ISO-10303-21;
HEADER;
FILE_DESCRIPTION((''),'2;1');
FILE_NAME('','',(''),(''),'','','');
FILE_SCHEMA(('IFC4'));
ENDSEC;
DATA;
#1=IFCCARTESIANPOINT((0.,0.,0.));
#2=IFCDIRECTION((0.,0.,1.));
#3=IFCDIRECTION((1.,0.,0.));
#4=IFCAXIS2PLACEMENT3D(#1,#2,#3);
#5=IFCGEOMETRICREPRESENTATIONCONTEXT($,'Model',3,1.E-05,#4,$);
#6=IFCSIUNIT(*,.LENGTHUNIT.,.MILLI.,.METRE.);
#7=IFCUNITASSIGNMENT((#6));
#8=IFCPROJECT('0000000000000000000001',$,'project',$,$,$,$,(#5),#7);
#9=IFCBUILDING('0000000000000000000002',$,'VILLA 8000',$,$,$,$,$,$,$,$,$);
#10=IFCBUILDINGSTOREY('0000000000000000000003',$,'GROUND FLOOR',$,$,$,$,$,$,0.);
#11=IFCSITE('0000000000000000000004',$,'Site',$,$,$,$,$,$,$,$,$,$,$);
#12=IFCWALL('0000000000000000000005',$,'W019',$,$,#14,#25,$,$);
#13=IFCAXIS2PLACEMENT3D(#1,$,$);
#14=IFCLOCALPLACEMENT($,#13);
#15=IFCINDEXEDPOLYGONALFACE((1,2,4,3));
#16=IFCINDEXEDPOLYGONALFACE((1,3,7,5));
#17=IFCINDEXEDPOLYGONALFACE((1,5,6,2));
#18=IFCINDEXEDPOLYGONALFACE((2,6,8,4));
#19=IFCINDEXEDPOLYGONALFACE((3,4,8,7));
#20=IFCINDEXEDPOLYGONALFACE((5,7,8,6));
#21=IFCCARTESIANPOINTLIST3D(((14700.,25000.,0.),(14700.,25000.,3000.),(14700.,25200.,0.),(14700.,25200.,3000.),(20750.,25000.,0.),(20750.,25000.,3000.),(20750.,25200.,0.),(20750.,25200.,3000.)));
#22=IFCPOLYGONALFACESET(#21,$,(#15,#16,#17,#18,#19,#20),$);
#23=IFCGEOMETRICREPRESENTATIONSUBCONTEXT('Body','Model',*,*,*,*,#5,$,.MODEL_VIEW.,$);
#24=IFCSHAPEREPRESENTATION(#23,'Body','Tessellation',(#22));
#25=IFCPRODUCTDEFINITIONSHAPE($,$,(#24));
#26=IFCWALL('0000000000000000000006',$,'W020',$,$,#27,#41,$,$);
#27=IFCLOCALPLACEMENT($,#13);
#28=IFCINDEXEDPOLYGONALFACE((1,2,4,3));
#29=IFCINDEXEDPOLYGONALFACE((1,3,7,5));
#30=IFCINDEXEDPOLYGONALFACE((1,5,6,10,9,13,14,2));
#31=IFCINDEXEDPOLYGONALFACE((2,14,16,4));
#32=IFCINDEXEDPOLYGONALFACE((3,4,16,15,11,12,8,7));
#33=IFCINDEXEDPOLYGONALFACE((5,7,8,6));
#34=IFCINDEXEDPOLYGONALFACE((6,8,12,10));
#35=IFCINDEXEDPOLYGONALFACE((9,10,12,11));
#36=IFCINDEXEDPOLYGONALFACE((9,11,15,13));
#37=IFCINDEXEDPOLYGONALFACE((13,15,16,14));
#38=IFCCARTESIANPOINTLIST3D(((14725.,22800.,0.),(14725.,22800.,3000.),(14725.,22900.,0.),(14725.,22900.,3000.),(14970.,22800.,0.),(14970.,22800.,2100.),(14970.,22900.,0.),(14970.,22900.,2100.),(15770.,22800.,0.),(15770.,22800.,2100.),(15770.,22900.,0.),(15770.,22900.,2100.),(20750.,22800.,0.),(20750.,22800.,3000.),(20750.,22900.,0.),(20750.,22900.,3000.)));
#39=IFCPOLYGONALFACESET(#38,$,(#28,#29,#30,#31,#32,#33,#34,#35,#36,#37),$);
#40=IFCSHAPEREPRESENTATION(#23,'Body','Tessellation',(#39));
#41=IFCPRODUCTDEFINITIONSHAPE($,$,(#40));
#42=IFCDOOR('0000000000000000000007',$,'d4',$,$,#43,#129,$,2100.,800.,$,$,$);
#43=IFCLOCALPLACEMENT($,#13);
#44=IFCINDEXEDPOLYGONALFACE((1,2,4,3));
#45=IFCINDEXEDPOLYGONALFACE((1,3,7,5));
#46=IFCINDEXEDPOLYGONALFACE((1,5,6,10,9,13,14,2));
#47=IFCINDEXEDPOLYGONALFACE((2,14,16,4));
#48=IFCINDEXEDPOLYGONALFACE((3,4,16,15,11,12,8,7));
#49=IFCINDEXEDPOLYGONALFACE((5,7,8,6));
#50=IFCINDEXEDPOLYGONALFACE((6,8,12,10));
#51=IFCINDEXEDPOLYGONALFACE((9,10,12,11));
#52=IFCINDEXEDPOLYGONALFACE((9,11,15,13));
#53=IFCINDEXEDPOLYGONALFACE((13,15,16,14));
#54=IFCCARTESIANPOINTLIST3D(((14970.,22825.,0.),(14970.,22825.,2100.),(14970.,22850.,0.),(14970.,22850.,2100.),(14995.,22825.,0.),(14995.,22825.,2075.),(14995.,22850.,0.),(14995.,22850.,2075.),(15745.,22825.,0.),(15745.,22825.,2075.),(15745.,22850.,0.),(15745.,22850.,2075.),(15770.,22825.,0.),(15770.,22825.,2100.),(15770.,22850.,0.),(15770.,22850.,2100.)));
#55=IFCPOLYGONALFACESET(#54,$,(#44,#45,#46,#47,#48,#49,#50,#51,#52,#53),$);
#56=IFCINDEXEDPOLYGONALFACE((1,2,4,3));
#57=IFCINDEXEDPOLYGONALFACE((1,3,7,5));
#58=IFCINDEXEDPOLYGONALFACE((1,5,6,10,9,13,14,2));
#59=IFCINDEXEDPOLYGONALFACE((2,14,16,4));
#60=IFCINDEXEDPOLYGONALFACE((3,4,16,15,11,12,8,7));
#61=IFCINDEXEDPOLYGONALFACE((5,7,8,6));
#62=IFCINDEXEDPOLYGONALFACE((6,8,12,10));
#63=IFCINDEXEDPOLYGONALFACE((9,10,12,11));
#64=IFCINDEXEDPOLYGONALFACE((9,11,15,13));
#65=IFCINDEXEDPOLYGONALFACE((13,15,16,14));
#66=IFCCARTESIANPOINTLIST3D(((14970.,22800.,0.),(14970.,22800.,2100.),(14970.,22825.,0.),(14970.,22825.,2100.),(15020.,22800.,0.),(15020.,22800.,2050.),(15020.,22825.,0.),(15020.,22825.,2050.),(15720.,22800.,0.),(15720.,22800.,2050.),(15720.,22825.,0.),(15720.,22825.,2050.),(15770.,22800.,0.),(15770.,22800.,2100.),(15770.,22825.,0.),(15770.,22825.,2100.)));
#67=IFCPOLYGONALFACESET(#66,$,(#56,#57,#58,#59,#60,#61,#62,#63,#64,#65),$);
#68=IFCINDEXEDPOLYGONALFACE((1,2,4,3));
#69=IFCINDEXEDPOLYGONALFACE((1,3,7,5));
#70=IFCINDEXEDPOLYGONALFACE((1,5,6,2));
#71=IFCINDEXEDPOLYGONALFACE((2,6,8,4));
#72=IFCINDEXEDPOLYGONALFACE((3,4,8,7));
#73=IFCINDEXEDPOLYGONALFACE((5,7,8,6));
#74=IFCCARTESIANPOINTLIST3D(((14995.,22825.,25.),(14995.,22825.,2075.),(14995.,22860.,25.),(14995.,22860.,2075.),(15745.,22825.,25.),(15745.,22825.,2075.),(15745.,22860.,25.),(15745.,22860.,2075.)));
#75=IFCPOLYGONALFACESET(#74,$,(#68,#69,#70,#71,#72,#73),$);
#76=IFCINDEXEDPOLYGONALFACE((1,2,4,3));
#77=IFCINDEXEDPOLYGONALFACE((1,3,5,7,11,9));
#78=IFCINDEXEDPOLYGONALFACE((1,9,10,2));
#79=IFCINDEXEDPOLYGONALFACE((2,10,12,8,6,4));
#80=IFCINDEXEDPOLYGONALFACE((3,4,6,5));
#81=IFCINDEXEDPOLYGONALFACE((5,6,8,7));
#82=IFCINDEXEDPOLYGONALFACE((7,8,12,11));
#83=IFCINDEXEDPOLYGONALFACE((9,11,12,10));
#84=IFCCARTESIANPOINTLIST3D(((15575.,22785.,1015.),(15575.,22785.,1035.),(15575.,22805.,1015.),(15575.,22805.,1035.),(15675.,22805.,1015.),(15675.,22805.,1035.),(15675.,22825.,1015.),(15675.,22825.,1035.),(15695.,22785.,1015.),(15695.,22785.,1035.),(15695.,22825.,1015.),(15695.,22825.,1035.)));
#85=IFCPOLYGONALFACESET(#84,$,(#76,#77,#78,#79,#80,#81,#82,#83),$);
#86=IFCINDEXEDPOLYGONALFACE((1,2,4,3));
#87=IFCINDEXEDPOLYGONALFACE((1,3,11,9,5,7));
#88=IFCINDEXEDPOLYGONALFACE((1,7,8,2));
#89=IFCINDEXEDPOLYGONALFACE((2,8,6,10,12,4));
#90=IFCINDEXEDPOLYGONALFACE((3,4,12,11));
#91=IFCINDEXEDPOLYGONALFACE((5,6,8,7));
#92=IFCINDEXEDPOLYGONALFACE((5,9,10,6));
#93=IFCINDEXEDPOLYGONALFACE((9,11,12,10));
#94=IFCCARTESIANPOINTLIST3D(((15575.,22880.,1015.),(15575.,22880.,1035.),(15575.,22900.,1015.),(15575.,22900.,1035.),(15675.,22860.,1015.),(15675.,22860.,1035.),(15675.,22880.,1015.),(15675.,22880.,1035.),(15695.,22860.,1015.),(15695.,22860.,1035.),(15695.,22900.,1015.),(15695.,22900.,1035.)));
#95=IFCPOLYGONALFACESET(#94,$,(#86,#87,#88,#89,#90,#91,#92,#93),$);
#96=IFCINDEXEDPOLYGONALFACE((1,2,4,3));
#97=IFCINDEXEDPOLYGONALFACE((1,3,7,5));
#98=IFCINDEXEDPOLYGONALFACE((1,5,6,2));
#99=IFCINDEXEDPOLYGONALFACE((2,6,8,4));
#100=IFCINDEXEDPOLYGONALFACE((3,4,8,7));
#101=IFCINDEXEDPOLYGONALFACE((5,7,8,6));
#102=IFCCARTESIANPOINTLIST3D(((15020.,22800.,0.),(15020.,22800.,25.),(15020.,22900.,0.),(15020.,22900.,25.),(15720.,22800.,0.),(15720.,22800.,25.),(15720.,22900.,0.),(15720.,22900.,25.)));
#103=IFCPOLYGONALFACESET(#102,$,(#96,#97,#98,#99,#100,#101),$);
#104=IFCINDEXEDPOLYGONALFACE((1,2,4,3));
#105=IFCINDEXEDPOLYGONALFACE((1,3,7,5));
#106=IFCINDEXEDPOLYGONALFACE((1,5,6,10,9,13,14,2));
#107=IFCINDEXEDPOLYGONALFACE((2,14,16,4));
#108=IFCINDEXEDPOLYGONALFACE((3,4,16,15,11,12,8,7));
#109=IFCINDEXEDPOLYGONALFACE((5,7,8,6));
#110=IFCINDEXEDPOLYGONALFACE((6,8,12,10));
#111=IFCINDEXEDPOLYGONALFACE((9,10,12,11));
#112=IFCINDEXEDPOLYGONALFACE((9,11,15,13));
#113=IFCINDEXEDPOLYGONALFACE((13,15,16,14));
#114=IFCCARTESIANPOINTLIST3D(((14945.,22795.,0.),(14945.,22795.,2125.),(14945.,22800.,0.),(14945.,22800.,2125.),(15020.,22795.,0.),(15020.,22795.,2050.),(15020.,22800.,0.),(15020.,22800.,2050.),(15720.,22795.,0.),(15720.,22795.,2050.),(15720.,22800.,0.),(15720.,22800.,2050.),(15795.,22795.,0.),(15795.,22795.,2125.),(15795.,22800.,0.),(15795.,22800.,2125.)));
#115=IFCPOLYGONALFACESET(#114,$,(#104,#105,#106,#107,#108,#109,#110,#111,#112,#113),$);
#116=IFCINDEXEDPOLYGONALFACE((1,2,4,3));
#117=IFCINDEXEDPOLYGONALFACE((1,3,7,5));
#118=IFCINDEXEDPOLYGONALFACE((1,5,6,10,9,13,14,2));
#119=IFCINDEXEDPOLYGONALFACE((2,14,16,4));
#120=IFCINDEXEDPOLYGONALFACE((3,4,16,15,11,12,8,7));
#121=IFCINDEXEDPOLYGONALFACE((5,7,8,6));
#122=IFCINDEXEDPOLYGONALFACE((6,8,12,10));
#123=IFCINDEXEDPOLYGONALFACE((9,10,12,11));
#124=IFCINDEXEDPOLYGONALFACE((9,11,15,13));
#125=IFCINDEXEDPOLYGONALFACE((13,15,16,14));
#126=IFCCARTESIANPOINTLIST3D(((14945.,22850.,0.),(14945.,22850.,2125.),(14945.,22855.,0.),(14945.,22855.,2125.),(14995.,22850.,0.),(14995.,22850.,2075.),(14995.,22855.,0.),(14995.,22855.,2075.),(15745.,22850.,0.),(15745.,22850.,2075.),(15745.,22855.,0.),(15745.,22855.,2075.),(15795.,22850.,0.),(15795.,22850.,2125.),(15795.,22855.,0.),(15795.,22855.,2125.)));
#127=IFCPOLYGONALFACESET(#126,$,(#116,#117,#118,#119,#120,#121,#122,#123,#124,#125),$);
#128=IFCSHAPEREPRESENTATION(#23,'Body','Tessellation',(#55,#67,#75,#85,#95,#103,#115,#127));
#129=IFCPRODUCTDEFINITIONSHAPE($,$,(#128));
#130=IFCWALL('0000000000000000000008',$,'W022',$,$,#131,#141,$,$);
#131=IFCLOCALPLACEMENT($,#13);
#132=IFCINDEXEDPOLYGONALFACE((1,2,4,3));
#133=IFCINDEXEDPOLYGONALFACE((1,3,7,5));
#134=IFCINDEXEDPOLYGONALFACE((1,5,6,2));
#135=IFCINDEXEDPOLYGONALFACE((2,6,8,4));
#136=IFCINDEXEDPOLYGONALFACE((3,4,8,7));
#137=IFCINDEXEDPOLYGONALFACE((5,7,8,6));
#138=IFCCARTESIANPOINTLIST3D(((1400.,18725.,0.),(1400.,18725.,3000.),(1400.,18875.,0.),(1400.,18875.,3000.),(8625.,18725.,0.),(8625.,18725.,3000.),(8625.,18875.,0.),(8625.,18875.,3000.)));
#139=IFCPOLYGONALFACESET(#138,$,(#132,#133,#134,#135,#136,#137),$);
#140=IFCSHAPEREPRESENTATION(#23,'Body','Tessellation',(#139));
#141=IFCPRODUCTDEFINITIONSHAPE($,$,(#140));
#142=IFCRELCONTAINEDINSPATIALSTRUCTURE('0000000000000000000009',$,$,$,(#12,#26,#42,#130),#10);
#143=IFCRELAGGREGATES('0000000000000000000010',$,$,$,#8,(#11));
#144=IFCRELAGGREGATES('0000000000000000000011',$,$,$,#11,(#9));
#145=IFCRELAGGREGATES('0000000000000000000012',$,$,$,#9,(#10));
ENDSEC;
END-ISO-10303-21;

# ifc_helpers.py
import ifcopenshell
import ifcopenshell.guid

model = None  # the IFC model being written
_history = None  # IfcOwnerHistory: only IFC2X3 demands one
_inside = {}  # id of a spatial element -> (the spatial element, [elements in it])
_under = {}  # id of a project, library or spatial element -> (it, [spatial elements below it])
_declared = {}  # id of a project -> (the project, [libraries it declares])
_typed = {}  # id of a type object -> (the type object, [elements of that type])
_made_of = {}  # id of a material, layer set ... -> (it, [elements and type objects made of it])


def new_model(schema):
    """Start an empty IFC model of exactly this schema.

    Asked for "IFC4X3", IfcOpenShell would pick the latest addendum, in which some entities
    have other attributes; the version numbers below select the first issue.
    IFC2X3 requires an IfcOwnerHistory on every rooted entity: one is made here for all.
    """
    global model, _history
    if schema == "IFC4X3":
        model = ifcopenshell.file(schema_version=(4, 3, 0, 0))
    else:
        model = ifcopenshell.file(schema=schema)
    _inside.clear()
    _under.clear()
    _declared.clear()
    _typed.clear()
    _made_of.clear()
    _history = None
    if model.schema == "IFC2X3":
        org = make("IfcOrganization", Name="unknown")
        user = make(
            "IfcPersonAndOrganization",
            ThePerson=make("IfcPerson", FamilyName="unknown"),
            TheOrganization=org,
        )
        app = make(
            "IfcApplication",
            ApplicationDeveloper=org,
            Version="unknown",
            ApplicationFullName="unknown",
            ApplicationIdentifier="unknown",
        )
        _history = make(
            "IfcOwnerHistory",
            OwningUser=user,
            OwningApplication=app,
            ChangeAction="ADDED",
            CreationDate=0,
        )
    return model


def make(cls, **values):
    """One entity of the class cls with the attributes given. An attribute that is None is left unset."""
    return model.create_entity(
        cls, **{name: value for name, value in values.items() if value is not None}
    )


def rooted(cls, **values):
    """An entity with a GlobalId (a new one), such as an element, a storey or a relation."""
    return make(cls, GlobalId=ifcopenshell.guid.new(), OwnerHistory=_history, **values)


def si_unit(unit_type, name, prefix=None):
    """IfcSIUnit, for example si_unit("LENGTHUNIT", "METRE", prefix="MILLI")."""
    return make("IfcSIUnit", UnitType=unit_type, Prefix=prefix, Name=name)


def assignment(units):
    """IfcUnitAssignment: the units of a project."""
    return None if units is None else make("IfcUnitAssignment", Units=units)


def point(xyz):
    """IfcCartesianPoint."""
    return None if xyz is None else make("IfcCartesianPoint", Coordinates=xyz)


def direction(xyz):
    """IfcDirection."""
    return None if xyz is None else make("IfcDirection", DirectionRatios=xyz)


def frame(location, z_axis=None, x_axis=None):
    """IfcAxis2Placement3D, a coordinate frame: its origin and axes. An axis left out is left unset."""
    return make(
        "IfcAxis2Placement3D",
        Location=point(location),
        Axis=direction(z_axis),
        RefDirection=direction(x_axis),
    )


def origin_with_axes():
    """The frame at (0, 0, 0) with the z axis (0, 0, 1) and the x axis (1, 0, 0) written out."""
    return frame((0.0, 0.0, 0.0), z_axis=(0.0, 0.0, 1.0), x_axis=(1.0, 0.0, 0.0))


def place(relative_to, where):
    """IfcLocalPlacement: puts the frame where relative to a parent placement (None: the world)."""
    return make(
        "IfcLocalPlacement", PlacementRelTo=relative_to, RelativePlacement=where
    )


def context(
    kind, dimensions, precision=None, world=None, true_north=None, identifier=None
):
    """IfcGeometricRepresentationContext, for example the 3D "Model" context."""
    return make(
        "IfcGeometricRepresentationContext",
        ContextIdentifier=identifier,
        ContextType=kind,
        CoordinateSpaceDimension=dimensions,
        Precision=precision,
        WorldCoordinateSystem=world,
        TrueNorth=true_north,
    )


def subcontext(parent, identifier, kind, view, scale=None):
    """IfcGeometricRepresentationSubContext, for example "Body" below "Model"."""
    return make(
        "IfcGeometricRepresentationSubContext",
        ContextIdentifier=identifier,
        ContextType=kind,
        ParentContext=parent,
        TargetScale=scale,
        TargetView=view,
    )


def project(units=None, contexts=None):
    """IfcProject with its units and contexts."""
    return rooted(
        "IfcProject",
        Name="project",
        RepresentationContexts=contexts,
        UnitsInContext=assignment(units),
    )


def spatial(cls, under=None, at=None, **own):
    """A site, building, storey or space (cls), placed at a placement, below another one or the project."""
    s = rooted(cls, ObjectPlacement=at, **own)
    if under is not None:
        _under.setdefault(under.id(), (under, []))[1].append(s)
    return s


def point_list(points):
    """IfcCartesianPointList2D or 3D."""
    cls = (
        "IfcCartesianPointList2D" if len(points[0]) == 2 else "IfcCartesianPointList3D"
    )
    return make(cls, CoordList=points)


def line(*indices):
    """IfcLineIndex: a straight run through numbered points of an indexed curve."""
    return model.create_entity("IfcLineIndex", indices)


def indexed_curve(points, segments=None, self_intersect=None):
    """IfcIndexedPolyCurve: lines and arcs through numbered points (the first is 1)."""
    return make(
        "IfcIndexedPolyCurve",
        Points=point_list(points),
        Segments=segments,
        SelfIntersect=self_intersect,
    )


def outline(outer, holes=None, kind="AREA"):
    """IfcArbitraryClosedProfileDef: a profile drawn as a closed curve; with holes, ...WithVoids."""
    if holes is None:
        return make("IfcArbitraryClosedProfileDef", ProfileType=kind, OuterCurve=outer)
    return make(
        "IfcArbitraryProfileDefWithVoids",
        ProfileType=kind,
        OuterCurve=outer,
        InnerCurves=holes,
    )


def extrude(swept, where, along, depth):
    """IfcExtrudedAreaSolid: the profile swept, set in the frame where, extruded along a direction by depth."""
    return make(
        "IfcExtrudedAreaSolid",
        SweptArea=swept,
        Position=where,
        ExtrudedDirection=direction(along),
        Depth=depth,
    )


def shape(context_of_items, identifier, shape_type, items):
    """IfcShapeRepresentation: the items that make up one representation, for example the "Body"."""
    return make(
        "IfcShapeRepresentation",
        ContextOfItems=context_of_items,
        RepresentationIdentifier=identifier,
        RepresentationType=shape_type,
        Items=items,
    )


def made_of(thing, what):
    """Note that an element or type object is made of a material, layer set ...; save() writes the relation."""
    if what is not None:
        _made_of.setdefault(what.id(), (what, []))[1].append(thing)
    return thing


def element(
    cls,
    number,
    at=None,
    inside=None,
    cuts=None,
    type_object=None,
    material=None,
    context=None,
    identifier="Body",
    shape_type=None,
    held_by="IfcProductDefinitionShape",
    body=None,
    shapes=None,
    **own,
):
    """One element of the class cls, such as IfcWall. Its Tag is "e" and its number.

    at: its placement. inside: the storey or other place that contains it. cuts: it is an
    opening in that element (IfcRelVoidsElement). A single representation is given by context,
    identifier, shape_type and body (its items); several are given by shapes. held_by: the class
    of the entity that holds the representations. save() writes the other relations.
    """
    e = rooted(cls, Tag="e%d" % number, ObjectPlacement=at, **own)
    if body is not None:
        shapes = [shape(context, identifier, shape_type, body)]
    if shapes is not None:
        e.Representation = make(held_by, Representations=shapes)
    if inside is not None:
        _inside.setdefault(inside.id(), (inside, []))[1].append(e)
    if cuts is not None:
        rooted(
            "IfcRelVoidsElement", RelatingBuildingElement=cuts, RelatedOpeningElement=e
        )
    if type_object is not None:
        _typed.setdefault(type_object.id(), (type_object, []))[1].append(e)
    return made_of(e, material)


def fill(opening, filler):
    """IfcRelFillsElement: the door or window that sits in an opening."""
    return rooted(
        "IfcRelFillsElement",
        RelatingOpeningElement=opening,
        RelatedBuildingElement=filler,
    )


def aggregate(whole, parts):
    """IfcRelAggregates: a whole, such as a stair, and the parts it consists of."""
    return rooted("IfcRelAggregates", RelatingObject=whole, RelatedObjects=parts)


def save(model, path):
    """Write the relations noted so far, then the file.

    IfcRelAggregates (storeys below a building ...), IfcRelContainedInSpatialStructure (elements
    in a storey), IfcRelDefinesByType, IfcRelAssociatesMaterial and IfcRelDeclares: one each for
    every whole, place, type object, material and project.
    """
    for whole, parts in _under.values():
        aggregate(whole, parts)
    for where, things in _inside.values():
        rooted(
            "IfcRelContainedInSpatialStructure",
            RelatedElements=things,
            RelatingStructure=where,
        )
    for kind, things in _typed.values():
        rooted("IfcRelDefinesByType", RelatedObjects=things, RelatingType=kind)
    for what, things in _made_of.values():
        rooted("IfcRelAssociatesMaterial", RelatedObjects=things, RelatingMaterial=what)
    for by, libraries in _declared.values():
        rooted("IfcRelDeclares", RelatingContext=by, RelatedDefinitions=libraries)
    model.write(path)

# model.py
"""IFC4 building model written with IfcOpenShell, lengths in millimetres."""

from ifc_helpers import new_model, si_unit, frame, origin_with_axes, place, context, subcontext, project, spatial, line, indexed_curve, outline, extrude, element, fill, save


model = new_model("IFC4")

# Units and contexts
model_context = context("Model", 3, precision=1e-05, world=origin_with_axes())
body_context = subcontext(model_context, "Body", "Model", "MODEL_VIEW")
ifc_project = project(units=[si_unit("LENGTHUNIT", "METRE", prefix="MILLI")], contexts=[model_context])

# Site, building, storey
site = spatial("IfcSite", under=ifc_project, Name="Site")
building = spatial("IfcBuilding", under=site, Name="VILLA 8000")
storey = spatial("IfcBuildingStorey", under=building, Name="GROUND FLOOR", Elevation=0.0)

# Wall
wall_1_placement = place(None, frame((14700.0, 25100.0, 0.0), z_axis=(0.0, 0.0, 1.0), x_axis=(1.0, 0.0, 0.0)))
element("IfcWall", 1, at=wall_1_placement, inside=storey, Name="W019", context=body_context, shape_type="SweptSolid", body=[
    extrude(outline(indexed_curve([(0.0, 0.0), (0.0, 200.0), (6050.0, 200.0), (6050.0, 0.0), (0.0, 0.0)], self_intersect=False)), frame((0.0, -100.0, 0.0), z_axis=(0.0, 0.0, 1.0), x_axis=(1.0, 0.0, 0.0)), (0.0, 0.0, 1.0), 3000.0),
])

# Wall, opening, door
wall_2_placement = place(None, frame((14725.0, 22850.0, 0.0), z_axis=(0.0, 0.0, 1.0), x_axis=(1.0, 0.0, 0.0)))
wall_2 = element("IfcWall", 2, at=wall_2_placement, inside=storey, Name="W020", context=body_context, shape_type="SweptSolid", body=[
    extrude(outline(indexed_curve([(0.0, 0.0), (0.0, 100.0), (6025.0, 100.0), (6025.0, 0.0), (0.0, 0.0)], self_intersect=False)), frame((0.0, -50.0, 0.0), z_axis=(0.0, 0.0, 1.0), x_axis=(1.0, 0.0, 0.0)), (0.0, 0.0, 1.0), 3000.0),
])
opening_1_placement = place(wall_2_placement, frame((245.0, 0.0, 0.0), z_axis=(0.0, 0.0, 1.0), x_axis=(1.0, 0.0, 0.0)))
opening_1 = element("IfcOpeningElement", 3, at=opening_1_placement, cuts=wall_2, context=body_context, shape_type="SweptSolid", body=[
    extrude(outline(indexed_curve([(0.0, 0.0), (0.0, 200.0), (800.0, 200.0), (800.0, 0.0), (0.0, 0.0)], self_intersect=False)), frame((0.0, -100.0, 0.0), z_axis=(0.0, 0.0, 1.0), x_axis=(1.0, 0.0, 0.0)), (0.0, 0.0, 1.0), 2100.0),
])
door_1_placement = place(None, frame((14970.0, 22800.0, 0.0), z_axis=(0.0, 0.0, 1.0), x_axis=(1.0, 0.0, 0.0)))
door_1 = element("IfcDoor", 4, at=door_1_placement, inside=storey, Name="d4", OverallHeight=2100.0, OverallWidth=800.0, context=body_context, shape_type="SweptSolid", body=[
    extrude(outline(indexed_curve([(0.0, 0.0), (0.0, 2100.0), (800.0, 2100.0), (800.0, 0.0), (775.0, 0.0), (775.0, 2075.0), (25.0, 2075.0), (25.0, 0.0)], segments=[line(1, 2, 3, 4, 5, 6, 7, 8, 1)])), frame((0.0, 25.0, 0.0), z_axis=(0.0, -1.0, 0.0), x_axis=(1.0, 0.0, 0.0)), (0.0, 0.0, -1.0), 25.0),
    extrude(outline(indexed_curve([(0.0, 0.0), (0.0, 2100.0), (800.0, 2100.0), (800.0, 0.0), (750.0, 0.0), (750.0, 2050.0), (50.0, 2050.0), (50.0, 0.0)], segments=[line(1, 2, 3, 4, 5, 6, 7, 8, 1)])), frame((0.0, 0.0, 0.0), z_axis=(0.0, -1.0, 0.0), x_axis=(1.0, 0.0, 0.0)), (0.0, 0.0, -1.0), 25.0),
    extrude(outline(indexed_curve([(0.0, 0.0), (750.0, 0.0), (750.0, 35.0), (0.0, 35.0)], segments=[line(1, 2, 3, 4, 1)])), frame((25.0, 25.0, 25.0), z_axis=(0.0, 0.0, 1.0), x_axis=(1.0, 0.0, 0.0)), (0.0, 0.0, 1.0), 2050.0),
    extrude(outline(indexed_curve([(0.0, 0.0), (0.0, -40.0), (-120.0, -40.0), (-120.0, -20.0), (-20.0, -20.0), (-20.0, 0.0)], segments=[line(1, 2, 3, 4, 5, 6, 1)])), frame((725.0, 25.0, 1015.0), z_axis=(0.0, 0.0, 1.0), x_axis=(1.0, 0.0, 0.0)), (0.0, 0.0, 1.0), 20.0),
    extrude(outline(indexed_curve([(0.0, 0.0), (0.0, 40.0), (-120.0, 40.0), (-120.0, 20.0), (-20.0, 20.0), (-20.0, 0.0)], segments=[line(1, 2, 3, 4, 5, 6, 1)])), frame((725.0, 60.0, 1015.0), z_axis=(0.0, 0.0, 1.0), x_axis=(1.0, 0.0, 0.0)), (0.0, 0.0, 1.0), 20.0),
    extrude(outline(indexed_curve([(0.0, 0.0), (700.0, 0.0), (700.0, 100.0), (0.0, 100.0)], segments=[line(1, 2, 3, 4, 1)])), frame((50.0, 0.0, 0.0), z_axis=(0.0, 0.0, 1.0), x_axis=(1.0, 0.0, 0.0)), (0.0, 0.0, 1.0), 25.0),
    extrude(outline(indexed_curve([(0.0, 0.0), (0.0, 2125.0), (850.0, 2125.0), (850.0, 0.0), (775.0, 0.0), (775.0, 2050.0), (75.0, 2050.0), (75.0, 0.0)], segments=[line(1, 2, 3, 4, 5, 6, 7, 8, 1)])), frame((-25.0, -5.0, 0.0), z_axis=(0.0, -1.0, 0.0), x_axis=(1.0, 0.0, 0.0)), (0.0, 0.0, -1.0), 5.0),
    extrude(outline(indexed_curve([(0.0, 0.0), (0.0, 2125.0), (850.0, 2125.0), (850.0, 0.0), (800.0, 0.0), (800.0, 2075.0), (50.0, 2075.0), (50.0, 0.0)], segments=[line(1, 2, 3, 4, 5, 6, 7, 8, 1)])), frame((-25.0, 50.0, 0.0), z_axis=(0.0, -1.0, 0.0), x_axis=(1.0, 0.0, 0.0)), (0.0, 0.0, -1.0), 5.0),
])
fill(opening_1, door_1)

# Wall
wall_3_placement = place(None, frame((1400.0, 18800.0, 0.0), z_axis=(0.0, 0.0, 1.0), x_axis=(1.0, 0.0, 0.0)))
element("IfcWall", 5, at=wall_3_placement, inside=storey, Name="W022", context=body_context, shape_type="SweptSolid", body=[
    extrude(outline(indexed_curve([(0.0, 0.0), (0.0, 150.0), (7225.0, 150.0), (7225.0, 0.0), (0.0, 0.0)], self_intersect=False)), frame((0.0, -75.0, 0.0), z_axis=(0.0, 0.0, 1.0), x_axis=(1.0, 0.0, 0.0)), (0.0, 0.0, 1.0), 3000.0),
])

save(model, "model.ifc")
